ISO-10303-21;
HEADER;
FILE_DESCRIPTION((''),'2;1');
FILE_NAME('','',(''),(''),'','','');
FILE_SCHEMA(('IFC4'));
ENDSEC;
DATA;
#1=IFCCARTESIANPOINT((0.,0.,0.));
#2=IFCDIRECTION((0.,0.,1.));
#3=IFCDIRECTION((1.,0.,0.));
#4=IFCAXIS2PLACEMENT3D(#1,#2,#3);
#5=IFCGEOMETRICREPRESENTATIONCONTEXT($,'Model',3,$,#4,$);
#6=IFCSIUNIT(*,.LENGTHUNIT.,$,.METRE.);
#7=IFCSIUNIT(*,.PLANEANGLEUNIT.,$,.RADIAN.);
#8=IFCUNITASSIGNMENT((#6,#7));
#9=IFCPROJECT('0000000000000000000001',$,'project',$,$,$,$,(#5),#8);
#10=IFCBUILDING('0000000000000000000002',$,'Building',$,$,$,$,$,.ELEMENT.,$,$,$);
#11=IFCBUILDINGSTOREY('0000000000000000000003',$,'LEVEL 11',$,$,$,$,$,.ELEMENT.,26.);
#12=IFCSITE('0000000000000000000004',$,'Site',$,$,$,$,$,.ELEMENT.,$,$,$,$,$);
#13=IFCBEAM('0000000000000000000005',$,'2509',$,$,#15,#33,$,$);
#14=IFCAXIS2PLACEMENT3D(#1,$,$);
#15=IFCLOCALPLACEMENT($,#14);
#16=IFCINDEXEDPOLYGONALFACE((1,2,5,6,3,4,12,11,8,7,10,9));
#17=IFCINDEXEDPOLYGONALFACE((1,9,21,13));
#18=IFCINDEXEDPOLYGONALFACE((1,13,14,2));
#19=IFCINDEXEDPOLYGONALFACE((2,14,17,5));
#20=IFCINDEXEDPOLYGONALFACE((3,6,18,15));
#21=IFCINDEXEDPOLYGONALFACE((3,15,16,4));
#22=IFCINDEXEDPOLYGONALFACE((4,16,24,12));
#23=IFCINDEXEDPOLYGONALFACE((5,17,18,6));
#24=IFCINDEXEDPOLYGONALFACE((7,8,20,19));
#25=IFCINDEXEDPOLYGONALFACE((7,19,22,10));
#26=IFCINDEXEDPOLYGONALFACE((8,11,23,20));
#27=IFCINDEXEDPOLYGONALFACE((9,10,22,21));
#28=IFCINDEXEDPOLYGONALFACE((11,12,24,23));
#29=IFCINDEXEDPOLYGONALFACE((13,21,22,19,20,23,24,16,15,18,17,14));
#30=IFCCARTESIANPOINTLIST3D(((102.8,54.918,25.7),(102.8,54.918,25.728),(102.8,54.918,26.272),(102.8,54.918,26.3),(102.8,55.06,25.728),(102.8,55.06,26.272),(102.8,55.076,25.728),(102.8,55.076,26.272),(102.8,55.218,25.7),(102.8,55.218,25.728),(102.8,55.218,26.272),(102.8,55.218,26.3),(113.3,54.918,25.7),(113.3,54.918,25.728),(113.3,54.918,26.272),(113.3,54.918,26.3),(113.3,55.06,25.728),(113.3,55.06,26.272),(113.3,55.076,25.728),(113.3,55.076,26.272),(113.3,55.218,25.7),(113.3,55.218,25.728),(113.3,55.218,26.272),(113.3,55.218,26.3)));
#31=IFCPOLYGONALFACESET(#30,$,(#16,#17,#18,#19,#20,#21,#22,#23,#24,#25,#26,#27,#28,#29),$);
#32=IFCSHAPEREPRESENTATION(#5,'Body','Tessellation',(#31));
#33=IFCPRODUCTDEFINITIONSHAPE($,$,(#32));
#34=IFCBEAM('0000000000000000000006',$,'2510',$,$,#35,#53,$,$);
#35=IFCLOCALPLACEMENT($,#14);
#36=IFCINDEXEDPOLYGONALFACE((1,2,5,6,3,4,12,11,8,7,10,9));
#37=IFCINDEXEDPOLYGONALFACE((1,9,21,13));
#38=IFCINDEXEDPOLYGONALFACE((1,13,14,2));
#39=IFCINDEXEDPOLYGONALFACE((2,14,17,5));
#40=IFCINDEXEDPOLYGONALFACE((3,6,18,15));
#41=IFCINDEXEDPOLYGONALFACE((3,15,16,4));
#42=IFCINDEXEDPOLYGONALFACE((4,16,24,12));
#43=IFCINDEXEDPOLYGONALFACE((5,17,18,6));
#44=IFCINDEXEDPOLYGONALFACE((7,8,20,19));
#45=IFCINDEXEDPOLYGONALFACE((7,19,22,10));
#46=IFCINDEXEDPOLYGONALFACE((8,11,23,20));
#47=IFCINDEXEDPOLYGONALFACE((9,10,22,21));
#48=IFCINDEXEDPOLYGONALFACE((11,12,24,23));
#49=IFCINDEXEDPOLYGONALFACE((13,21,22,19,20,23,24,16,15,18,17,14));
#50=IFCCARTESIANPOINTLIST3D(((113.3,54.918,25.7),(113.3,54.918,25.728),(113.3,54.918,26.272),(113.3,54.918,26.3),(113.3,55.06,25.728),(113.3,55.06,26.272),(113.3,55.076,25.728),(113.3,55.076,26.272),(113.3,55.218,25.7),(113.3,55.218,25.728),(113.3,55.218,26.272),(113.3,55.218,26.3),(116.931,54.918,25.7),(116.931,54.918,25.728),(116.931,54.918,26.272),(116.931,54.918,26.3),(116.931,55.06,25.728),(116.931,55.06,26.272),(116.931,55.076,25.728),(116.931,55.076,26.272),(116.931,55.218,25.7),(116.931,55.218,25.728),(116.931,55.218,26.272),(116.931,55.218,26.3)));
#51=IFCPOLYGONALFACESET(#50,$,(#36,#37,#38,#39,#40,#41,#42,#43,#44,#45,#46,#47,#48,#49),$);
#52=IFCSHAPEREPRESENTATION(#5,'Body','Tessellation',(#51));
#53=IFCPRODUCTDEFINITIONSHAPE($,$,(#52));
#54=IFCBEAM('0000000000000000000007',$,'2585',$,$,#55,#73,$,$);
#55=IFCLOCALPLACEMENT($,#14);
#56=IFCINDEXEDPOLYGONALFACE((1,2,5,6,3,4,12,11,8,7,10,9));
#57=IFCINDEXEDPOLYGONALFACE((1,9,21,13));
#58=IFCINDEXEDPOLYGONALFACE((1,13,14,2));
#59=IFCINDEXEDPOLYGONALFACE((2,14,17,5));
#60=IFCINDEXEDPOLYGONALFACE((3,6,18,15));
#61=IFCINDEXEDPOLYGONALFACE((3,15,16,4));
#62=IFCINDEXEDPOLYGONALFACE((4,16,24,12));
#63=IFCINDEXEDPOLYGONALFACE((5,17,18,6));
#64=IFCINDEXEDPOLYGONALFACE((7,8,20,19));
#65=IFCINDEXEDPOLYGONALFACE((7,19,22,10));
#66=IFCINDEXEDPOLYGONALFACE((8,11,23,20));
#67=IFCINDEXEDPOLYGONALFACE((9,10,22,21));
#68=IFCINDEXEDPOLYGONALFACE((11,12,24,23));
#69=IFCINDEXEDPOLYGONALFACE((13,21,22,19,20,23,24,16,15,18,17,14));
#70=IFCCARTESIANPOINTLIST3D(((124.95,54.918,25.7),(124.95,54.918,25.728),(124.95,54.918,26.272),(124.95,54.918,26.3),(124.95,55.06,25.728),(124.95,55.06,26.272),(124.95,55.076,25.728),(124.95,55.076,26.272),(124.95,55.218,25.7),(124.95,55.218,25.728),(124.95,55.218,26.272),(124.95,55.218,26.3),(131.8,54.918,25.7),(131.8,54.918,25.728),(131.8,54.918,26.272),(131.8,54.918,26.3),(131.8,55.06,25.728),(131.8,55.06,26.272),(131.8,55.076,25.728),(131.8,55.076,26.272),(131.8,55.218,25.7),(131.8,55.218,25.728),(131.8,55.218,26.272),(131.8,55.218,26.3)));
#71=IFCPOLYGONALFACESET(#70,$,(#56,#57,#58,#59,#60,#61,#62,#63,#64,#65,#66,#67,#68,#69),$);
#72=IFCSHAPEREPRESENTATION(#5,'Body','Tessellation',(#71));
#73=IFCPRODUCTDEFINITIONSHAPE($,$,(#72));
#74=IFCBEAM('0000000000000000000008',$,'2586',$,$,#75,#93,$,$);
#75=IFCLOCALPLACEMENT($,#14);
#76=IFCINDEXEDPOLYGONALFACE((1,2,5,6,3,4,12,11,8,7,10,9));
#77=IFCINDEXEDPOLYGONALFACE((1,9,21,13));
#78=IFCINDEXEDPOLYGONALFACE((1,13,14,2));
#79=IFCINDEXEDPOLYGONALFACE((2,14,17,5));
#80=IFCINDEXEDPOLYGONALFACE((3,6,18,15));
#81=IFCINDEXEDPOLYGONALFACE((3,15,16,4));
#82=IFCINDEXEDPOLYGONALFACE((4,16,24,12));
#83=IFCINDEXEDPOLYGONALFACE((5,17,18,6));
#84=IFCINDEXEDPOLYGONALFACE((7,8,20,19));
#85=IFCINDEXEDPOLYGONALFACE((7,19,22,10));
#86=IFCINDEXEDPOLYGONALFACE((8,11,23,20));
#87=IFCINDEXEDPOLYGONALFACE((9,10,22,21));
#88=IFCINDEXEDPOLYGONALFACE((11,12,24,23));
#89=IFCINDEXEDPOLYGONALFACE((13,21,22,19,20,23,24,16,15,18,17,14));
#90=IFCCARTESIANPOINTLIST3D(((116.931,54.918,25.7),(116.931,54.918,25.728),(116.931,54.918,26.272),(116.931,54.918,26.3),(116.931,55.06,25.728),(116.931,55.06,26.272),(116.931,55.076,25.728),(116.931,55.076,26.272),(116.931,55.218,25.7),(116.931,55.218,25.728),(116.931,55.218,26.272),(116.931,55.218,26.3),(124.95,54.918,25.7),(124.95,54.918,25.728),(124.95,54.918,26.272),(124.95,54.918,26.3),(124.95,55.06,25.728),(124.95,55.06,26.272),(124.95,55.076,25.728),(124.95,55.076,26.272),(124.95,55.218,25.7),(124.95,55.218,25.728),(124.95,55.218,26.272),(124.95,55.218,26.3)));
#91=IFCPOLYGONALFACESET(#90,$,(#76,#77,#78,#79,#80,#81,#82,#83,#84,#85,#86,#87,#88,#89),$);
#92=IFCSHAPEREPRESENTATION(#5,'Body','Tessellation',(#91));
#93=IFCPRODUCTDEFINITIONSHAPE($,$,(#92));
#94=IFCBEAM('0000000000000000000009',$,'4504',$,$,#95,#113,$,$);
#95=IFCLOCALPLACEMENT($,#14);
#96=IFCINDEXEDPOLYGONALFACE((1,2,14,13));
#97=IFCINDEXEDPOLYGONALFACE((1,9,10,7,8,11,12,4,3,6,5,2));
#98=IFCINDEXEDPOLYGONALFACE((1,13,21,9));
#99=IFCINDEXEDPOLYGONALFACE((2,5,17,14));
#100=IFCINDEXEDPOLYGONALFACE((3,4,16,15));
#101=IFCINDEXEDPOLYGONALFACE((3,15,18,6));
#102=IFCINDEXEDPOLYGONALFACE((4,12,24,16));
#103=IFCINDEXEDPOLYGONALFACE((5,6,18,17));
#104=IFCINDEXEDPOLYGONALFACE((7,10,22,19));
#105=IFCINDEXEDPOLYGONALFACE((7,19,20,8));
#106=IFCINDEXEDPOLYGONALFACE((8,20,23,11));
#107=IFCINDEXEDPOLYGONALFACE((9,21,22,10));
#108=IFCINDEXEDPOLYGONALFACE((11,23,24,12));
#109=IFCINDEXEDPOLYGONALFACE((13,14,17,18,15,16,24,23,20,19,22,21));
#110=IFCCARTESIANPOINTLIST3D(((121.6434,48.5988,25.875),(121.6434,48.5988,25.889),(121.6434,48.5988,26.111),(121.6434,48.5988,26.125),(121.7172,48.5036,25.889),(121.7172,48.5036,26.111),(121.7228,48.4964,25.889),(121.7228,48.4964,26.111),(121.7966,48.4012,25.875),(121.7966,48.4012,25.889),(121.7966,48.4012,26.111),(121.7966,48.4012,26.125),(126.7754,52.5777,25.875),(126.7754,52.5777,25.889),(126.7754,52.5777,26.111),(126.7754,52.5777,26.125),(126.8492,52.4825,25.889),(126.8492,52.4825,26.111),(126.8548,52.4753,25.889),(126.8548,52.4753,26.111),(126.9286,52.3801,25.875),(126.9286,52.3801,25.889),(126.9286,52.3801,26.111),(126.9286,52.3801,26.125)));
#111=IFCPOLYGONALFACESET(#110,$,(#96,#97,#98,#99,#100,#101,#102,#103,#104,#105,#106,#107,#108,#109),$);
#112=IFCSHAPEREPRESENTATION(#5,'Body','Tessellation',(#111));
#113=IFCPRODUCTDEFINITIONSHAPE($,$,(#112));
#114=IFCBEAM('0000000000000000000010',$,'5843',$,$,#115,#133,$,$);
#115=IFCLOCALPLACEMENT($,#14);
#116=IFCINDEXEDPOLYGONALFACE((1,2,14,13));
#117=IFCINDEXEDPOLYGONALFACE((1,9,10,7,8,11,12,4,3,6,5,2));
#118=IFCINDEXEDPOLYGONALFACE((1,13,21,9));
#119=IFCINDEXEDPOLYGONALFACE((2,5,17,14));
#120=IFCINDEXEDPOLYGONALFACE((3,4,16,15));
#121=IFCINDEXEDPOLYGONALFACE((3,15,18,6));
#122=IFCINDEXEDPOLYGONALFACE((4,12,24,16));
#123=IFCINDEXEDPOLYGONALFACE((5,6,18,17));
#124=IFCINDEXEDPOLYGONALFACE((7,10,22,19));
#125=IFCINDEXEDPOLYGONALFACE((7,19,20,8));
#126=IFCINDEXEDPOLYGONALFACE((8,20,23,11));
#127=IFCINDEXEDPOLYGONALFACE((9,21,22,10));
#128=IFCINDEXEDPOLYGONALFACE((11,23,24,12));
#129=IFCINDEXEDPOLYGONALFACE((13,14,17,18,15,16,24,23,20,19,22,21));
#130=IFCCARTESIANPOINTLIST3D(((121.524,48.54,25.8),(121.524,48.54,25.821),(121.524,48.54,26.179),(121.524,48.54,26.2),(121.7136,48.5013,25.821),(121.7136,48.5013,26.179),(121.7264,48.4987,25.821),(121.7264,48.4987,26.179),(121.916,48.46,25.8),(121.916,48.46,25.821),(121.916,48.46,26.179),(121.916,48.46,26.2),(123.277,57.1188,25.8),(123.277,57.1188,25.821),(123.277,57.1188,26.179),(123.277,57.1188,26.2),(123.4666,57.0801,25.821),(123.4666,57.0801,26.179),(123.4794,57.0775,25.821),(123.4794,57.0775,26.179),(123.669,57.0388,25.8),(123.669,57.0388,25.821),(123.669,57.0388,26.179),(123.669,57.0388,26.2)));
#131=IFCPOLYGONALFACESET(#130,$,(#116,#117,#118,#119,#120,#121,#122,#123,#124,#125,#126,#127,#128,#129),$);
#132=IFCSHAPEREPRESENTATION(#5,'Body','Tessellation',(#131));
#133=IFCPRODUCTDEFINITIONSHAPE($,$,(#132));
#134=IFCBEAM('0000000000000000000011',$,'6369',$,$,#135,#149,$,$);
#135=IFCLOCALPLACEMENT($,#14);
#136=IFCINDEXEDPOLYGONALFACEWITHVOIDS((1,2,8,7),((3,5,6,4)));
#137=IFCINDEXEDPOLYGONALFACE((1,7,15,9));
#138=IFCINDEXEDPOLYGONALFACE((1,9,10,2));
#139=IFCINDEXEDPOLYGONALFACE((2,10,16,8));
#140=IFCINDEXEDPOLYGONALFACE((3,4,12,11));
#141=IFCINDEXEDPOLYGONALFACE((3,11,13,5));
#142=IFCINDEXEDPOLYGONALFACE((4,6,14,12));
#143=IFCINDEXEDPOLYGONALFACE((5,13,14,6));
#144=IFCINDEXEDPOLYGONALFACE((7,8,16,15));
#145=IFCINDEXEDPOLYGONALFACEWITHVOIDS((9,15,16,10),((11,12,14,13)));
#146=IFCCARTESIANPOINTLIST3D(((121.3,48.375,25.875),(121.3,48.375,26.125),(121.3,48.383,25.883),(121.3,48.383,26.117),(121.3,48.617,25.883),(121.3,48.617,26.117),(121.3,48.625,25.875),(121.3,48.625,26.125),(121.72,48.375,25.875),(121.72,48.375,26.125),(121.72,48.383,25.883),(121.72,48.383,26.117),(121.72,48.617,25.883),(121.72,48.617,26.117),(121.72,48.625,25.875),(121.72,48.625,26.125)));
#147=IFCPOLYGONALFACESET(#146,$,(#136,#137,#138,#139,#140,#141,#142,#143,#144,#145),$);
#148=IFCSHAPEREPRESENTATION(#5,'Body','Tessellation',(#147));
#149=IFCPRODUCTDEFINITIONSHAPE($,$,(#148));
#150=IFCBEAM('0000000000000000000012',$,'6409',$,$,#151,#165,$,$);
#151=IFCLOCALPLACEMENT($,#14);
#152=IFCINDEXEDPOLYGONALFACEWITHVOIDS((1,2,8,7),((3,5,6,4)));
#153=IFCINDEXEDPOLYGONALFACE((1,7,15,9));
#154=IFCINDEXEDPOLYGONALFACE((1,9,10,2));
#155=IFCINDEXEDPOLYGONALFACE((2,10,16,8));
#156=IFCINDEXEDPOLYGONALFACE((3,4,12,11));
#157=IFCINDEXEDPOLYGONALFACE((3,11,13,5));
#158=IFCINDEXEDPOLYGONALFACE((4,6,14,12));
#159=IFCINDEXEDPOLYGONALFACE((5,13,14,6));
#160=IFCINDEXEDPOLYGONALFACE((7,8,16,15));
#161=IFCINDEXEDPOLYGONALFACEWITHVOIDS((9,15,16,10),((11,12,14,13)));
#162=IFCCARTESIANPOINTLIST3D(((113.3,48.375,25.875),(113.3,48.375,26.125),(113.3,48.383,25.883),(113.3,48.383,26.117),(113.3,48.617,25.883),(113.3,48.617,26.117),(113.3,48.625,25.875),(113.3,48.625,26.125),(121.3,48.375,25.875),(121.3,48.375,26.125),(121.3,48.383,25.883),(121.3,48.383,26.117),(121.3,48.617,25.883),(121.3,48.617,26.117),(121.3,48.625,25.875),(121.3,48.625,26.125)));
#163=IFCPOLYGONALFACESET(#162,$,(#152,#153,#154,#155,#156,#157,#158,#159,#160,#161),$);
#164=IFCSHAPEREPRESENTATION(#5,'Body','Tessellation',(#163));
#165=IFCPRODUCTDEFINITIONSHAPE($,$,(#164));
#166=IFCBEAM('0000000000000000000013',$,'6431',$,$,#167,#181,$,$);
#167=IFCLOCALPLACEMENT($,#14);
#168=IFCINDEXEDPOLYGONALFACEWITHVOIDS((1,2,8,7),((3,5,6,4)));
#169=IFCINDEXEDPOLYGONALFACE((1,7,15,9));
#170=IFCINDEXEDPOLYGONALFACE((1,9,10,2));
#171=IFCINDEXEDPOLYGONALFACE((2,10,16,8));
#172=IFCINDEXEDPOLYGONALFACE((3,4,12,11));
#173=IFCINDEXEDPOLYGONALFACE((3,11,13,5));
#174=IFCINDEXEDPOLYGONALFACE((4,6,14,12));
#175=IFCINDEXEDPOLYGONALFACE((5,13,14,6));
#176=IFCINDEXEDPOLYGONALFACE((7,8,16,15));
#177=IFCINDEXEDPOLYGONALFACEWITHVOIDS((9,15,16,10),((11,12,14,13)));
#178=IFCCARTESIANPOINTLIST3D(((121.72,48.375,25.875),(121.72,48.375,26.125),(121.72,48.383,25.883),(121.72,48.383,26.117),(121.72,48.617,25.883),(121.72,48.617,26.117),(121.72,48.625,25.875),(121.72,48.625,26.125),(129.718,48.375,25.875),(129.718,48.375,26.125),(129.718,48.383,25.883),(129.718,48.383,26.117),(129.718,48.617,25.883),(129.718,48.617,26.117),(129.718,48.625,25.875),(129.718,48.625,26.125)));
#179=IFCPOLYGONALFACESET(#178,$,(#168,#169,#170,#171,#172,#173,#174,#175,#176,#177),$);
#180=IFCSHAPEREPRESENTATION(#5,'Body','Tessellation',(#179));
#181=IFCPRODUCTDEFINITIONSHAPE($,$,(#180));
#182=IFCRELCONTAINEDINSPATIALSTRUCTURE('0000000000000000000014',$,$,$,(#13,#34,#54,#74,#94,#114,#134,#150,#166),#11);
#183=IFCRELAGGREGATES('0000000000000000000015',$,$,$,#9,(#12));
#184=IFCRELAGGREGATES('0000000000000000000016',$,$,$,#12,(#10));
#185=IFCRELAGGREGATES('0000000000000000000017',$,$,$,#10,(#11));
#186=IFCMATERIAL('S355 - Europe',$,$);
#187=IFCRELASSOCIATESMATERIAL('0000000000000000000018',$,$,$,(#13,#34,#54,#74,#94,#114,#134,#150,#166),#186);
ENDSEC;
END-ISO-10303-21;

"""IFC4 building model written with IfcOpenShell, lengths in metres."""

from ifc_helpers import new_model, si_unit, frame, origin_with_axes, origin_2d_with_axis, place, context, project, spatial, hollow_rectangle, i_section, extrude, material, material_profile, profile_set, profile_usage, element, save


model = new_model("IFC4")

# Units and contexts
model_context = context("Model", 3, world=origin_with_axes())
ifc_project = project(units=[si_unit("LENGTHUNIT", "METRE"), si_unit("PLANEANGLEUNIT", "RADIAN")], contexts=[model_context])

# Site, building, storey
site = spatial("IfcSite", under=ifc_project, Name="Site", CompositionType="ELEMENT")
building = spatial("IfcBuilding", under=site, Name="Building", CompositionType="ELEMENT")
storey = spatial("IfcBuildingStorey", under=building, Name="LEVEL 11", CompositionType="ELEMENT", Elevation=26.0)

# Shared definitions
ifc_material = material(Name="S355 - Europe")

# Beams
ifc_material_profile_1 = material_profile(ifc_material, i_section(OverallWidth=0.3, OverallDepth=0.6, WebThickness=0.016, FlangeThickness=0.028, at=origin_2d_with_axis()))
ifc_profile_set_1 = profile_set([ifc_material_profile_1])
ifc_profile_usage_1 = profile_usage(ifc_profile_set_1, cardinal=10)
beam_1_placement = place(None, frame((102.8, 55.068, 26.0), z_axis=(1.0, 0.0, 0.0), x_axis=(0.0, 1.0, 0.0)))
element("IfcBeam", 1, at=beam_1_placement, inside=storey, material=ifc_profile_usage_1, Name="2509", context=model_context, shape_type="SweptSolid", body=[
    extrude(i_section(OverallWidth=0.3, OverallDepth=0.6, WebThickness=0.016, FlangeThickness=0.028, at=origin_2d_with_axis()), origin_with_axes(), (0.0, 0.0, 1.0), 10.5),
])
ifc_material_profile_2 = material_profile(ifc_material, i_section(OverallWidth=0.3, OverallDepth=0.6, WebThickness=0.016, FlangeThickness=0.028, at=origin_2d_with_axis()))
ifc_profile_set_2 = profile_set([ifc_material_profile_2])
ifc_profile_usage_2 = profile_usage(ifc_profile_set_2, cardinal=10)
beam_2_placement = place(None, frame((113.3, 55.068, 26.0), z_axis=(1.0, 0.0, 0.0), x_axis=(0.0, 1.0, 0.0)))
element("IfcBeam", 2, at=beam_2_placement, inside=storey, material=ifc_profile_usage_2, Name="2510", context=model_context, shape_type="SweptSolid", body=[
    extrude(i_section(OverallWidth=0.3, OverallDepth=0.6, WebThickness=0.016, FlangeThickness=0.028, at=origin_2d_with_axis()), origin_with_axes(), (0.0, 0.0, 1.0), 3.631),
])
ifc_material_profile_3 = material_profile(ifc_material, i_section(OverallWidth=0.3, OverallDepth=0.6, WebThickness=0.016, FlangeThickness=0.028, at=origin_2d_with_axis()))
ifc_profile_set_3 = profile_set([ifc_material_profile_3])
ifc_profile_usage_3 = profile_usage(ifc_profile_set_3, cardinal=10)
beam_3_placement = place(None, frame((124.95, 55.068, 26.0), z_axis=(1.0, 0.0, 0.0), x_axis=(0.0, 1.0, 0.0)))
element("IfcBeam", 3, at=beam_3_placement, inside=storey, material=ifc_profile_usage_3, Name="2585", context=model_context, shape_type="SweptSolid", body=[
    extrude(i_section(OverallWidth=0.3, OverallDepth=0.6, WebThickness=0.016, FlangeThickness=0.028, at=origin_2d_with_axis()), origin_with_axes(), (0.0, 0.0, 1.0), 6.85),
])
ifc_material_profile_4 = material_profile(ifc_material, i_section(OverallWidth=0.3, OverallDepth=0.6, WebThickness=0.016, FlangeThickness=0.028, at=origin_2d_with_axis()))
ifc_profile_set_4 = profile_set([ifc_material_profile_4])
ifc_profile_usage_4 = profile_usage(ifc_profile_set_4, cardinal=10)
beam_4_placement = place(None, frame((116.931, 55.068, 26.0), z_axis=(1.0, 0.0, 0.0), x_axis=(0.0, 1.0, 0.0)))
element("IfcBeam", 4, at=beam_4_placement, inside=storey, material=ifc_profile_usage_4, Name="2586", context=model_context, shape_type="SweptSolid", body=[
    extrude(i_section(OverallWidth=0.3, OverallDepth=0.6, WebThickness=0.016, FlangeThickness=0.028, at=origin_2d_with_axis()), origin_with_axes(), (0.0, 0.0, 1.0), 8.019),
])
ifc_material_profile_5 = material_profile(ifc_material, i_section(OverallWidth=0.25, OverallDepth=0.25, WebThickness=0.009, FlangeThickness=0.014, at=origin_2d_with_axis()))
ifc_profile_set_5 = profile_set([ifc_material_profile_5])
ifc_profile_usage_5 = profile_usage(ifc_profile_set_5, cardinal=10)
beam_5_placement = place(None, frame((126.852, 52.4789, 26.0), z_axis=(-0.790296, -0.612726, 0.0), x_axis=(0.612726, -0.790296, 0.0)))
element("IfcBeam", 5, at=beam_5_placement, inside=storey, material=ifc_profile_usage_5, Name="4504", context=model_context, shape_type="SweptSolid", body=[
    extrude(i_section(OverallWidth=0.25, OverallDepth=0.25, WebThickness=0.009, FlangeThickness=0.014, at=origin_2d_with_axis()), origin_with_axes(), (0.0, 0.0, 1.0), 6.4938),
])
ifc_material_profile_6 = material_profile(ifc_material, i_section(OverallWidth=0.4, OverallDepth=0.4, WebThickness=0.013, FlangeThickness=0.021, at=origin_2d_with_axis()))
ifc_profile_set_6 = profile_set([ifc_material_profile_6])
ifc_profile_usage_6 = profile_usage(ifc_profile_set_6, cardinal=10)
beam_6_placement = place(None, frame((121.72, 48.5, 26.0), z_axis=(0.200204, 0.979754, 0.0), x_axis=(-0.979754, 0.200204, 0.0)))
element("IfcBeam", 6, at=beam_6_placement, inside=storey, material=ifc_profile_usage_6, Name="5843", context=model_context, shape_type="SweptSolid", body=[
    extrude(i_section(OverallWidth=0.4, OverallDepth=0.4, WebThickness=0.013, FlangeThickness=0.021, at=origin_2d_with_axis()), origin_with_axes(), (0.0, 0.0, 1.0), 8.7561),
])
ifc_material_profile_7 = material_profile(ifc_material, hollow_rectangle(XDim=0.25, YDim=0.25, WallThickness=0.008, at=origin_2d_with_axis()))
ifc_profile_set_7 = profile_set([ifc_material_profile_7])
ifc_profile_usage_7 = profile_usage(ifc_profile_set_7, cardinal=10)
beam_7_placement = place(None, frame((121.3, 48.5, 26.0), z_axis=(1.0, 0.0, 0.0), x_axis=(0.0, 1.0, 0.0)))
element("IfcBeam", 7, at=beam_7_placement, inside=storey, material=ifc_profile_usage_7, Name="6369", context=model_context, shape_type="SweptSolid", body=[
    extrude(hollow_rectangle(XDim=0.25, YDim=0.25, WallThickness=0.008, at=origin_2d_with_axis()), origin_with_axes(), (0.0, 0.0, 1.0), 0.42),
])
ifc_material_profile_8 = material_profile(ifc_material, hollow_rectangle(XDim=0.25, YDim=0.25, WallThickness=0.008, at=origin_2d_with_axis()))
ifc_profile_set_8 = profile_set([ifc_material_profile_8])
ifc_profile_usage_8 = profile_usage(ifc_profile_set_8, cardinal=10)
beam_8_placement = place(None, frame((113.3, 48.5, 26.0), z_axis=(1.0, 0.0, 0.0), x_axis=(0.0, 1.0, 0.0)))
element("IfcBeam", 8, at=beam_8_placement, inside=storey, material=ifc_profile_usage_8, Name="6409", context=model_context, shape_type="SweptSolid", body=[
    extrude(hollow_rectangle(XDim=0.25, YDim=0.25, WallThickness=0.008, at=origin_2d_with_axis()), origin_with_axes(), (0.0, 0.0, 1.0), 8.0),
])
ifc_material_profile_9 = material_profile(ifc_material, hollow_rectangle(XDim=0.25, YDim=0.25, WallThickness=0.008, at=origin_2d_with_axis()))
ifc_profile_set_9 = profile_set([ifc_material_profile_9])
ifc_profile_usage_9 = profile_usage(ifc_profile_set_9, cardinal=10)
beam_9_placement = place(None, frame((121.72, 48.5, 26.0), z_axis=(1.0, 0.0, 0.0), x_axis=(0.0, 1.0, 0.0)))
element("IfcBeam", 9, at=beam_9_placement, inside=storey, material=ifc_profile_usage_9, Name="6431", context=model_context, shape_type="SweptSolid", body=[
    extrude(hollow_rectangle(XDim=0.25, YDim=0.25, WallThickness=0.008, at=origin_2d_with_axis()), origin_with_axes(), (0.0, 0.0, 1.0), 7.998),
])

save(model, "model.ifc")
